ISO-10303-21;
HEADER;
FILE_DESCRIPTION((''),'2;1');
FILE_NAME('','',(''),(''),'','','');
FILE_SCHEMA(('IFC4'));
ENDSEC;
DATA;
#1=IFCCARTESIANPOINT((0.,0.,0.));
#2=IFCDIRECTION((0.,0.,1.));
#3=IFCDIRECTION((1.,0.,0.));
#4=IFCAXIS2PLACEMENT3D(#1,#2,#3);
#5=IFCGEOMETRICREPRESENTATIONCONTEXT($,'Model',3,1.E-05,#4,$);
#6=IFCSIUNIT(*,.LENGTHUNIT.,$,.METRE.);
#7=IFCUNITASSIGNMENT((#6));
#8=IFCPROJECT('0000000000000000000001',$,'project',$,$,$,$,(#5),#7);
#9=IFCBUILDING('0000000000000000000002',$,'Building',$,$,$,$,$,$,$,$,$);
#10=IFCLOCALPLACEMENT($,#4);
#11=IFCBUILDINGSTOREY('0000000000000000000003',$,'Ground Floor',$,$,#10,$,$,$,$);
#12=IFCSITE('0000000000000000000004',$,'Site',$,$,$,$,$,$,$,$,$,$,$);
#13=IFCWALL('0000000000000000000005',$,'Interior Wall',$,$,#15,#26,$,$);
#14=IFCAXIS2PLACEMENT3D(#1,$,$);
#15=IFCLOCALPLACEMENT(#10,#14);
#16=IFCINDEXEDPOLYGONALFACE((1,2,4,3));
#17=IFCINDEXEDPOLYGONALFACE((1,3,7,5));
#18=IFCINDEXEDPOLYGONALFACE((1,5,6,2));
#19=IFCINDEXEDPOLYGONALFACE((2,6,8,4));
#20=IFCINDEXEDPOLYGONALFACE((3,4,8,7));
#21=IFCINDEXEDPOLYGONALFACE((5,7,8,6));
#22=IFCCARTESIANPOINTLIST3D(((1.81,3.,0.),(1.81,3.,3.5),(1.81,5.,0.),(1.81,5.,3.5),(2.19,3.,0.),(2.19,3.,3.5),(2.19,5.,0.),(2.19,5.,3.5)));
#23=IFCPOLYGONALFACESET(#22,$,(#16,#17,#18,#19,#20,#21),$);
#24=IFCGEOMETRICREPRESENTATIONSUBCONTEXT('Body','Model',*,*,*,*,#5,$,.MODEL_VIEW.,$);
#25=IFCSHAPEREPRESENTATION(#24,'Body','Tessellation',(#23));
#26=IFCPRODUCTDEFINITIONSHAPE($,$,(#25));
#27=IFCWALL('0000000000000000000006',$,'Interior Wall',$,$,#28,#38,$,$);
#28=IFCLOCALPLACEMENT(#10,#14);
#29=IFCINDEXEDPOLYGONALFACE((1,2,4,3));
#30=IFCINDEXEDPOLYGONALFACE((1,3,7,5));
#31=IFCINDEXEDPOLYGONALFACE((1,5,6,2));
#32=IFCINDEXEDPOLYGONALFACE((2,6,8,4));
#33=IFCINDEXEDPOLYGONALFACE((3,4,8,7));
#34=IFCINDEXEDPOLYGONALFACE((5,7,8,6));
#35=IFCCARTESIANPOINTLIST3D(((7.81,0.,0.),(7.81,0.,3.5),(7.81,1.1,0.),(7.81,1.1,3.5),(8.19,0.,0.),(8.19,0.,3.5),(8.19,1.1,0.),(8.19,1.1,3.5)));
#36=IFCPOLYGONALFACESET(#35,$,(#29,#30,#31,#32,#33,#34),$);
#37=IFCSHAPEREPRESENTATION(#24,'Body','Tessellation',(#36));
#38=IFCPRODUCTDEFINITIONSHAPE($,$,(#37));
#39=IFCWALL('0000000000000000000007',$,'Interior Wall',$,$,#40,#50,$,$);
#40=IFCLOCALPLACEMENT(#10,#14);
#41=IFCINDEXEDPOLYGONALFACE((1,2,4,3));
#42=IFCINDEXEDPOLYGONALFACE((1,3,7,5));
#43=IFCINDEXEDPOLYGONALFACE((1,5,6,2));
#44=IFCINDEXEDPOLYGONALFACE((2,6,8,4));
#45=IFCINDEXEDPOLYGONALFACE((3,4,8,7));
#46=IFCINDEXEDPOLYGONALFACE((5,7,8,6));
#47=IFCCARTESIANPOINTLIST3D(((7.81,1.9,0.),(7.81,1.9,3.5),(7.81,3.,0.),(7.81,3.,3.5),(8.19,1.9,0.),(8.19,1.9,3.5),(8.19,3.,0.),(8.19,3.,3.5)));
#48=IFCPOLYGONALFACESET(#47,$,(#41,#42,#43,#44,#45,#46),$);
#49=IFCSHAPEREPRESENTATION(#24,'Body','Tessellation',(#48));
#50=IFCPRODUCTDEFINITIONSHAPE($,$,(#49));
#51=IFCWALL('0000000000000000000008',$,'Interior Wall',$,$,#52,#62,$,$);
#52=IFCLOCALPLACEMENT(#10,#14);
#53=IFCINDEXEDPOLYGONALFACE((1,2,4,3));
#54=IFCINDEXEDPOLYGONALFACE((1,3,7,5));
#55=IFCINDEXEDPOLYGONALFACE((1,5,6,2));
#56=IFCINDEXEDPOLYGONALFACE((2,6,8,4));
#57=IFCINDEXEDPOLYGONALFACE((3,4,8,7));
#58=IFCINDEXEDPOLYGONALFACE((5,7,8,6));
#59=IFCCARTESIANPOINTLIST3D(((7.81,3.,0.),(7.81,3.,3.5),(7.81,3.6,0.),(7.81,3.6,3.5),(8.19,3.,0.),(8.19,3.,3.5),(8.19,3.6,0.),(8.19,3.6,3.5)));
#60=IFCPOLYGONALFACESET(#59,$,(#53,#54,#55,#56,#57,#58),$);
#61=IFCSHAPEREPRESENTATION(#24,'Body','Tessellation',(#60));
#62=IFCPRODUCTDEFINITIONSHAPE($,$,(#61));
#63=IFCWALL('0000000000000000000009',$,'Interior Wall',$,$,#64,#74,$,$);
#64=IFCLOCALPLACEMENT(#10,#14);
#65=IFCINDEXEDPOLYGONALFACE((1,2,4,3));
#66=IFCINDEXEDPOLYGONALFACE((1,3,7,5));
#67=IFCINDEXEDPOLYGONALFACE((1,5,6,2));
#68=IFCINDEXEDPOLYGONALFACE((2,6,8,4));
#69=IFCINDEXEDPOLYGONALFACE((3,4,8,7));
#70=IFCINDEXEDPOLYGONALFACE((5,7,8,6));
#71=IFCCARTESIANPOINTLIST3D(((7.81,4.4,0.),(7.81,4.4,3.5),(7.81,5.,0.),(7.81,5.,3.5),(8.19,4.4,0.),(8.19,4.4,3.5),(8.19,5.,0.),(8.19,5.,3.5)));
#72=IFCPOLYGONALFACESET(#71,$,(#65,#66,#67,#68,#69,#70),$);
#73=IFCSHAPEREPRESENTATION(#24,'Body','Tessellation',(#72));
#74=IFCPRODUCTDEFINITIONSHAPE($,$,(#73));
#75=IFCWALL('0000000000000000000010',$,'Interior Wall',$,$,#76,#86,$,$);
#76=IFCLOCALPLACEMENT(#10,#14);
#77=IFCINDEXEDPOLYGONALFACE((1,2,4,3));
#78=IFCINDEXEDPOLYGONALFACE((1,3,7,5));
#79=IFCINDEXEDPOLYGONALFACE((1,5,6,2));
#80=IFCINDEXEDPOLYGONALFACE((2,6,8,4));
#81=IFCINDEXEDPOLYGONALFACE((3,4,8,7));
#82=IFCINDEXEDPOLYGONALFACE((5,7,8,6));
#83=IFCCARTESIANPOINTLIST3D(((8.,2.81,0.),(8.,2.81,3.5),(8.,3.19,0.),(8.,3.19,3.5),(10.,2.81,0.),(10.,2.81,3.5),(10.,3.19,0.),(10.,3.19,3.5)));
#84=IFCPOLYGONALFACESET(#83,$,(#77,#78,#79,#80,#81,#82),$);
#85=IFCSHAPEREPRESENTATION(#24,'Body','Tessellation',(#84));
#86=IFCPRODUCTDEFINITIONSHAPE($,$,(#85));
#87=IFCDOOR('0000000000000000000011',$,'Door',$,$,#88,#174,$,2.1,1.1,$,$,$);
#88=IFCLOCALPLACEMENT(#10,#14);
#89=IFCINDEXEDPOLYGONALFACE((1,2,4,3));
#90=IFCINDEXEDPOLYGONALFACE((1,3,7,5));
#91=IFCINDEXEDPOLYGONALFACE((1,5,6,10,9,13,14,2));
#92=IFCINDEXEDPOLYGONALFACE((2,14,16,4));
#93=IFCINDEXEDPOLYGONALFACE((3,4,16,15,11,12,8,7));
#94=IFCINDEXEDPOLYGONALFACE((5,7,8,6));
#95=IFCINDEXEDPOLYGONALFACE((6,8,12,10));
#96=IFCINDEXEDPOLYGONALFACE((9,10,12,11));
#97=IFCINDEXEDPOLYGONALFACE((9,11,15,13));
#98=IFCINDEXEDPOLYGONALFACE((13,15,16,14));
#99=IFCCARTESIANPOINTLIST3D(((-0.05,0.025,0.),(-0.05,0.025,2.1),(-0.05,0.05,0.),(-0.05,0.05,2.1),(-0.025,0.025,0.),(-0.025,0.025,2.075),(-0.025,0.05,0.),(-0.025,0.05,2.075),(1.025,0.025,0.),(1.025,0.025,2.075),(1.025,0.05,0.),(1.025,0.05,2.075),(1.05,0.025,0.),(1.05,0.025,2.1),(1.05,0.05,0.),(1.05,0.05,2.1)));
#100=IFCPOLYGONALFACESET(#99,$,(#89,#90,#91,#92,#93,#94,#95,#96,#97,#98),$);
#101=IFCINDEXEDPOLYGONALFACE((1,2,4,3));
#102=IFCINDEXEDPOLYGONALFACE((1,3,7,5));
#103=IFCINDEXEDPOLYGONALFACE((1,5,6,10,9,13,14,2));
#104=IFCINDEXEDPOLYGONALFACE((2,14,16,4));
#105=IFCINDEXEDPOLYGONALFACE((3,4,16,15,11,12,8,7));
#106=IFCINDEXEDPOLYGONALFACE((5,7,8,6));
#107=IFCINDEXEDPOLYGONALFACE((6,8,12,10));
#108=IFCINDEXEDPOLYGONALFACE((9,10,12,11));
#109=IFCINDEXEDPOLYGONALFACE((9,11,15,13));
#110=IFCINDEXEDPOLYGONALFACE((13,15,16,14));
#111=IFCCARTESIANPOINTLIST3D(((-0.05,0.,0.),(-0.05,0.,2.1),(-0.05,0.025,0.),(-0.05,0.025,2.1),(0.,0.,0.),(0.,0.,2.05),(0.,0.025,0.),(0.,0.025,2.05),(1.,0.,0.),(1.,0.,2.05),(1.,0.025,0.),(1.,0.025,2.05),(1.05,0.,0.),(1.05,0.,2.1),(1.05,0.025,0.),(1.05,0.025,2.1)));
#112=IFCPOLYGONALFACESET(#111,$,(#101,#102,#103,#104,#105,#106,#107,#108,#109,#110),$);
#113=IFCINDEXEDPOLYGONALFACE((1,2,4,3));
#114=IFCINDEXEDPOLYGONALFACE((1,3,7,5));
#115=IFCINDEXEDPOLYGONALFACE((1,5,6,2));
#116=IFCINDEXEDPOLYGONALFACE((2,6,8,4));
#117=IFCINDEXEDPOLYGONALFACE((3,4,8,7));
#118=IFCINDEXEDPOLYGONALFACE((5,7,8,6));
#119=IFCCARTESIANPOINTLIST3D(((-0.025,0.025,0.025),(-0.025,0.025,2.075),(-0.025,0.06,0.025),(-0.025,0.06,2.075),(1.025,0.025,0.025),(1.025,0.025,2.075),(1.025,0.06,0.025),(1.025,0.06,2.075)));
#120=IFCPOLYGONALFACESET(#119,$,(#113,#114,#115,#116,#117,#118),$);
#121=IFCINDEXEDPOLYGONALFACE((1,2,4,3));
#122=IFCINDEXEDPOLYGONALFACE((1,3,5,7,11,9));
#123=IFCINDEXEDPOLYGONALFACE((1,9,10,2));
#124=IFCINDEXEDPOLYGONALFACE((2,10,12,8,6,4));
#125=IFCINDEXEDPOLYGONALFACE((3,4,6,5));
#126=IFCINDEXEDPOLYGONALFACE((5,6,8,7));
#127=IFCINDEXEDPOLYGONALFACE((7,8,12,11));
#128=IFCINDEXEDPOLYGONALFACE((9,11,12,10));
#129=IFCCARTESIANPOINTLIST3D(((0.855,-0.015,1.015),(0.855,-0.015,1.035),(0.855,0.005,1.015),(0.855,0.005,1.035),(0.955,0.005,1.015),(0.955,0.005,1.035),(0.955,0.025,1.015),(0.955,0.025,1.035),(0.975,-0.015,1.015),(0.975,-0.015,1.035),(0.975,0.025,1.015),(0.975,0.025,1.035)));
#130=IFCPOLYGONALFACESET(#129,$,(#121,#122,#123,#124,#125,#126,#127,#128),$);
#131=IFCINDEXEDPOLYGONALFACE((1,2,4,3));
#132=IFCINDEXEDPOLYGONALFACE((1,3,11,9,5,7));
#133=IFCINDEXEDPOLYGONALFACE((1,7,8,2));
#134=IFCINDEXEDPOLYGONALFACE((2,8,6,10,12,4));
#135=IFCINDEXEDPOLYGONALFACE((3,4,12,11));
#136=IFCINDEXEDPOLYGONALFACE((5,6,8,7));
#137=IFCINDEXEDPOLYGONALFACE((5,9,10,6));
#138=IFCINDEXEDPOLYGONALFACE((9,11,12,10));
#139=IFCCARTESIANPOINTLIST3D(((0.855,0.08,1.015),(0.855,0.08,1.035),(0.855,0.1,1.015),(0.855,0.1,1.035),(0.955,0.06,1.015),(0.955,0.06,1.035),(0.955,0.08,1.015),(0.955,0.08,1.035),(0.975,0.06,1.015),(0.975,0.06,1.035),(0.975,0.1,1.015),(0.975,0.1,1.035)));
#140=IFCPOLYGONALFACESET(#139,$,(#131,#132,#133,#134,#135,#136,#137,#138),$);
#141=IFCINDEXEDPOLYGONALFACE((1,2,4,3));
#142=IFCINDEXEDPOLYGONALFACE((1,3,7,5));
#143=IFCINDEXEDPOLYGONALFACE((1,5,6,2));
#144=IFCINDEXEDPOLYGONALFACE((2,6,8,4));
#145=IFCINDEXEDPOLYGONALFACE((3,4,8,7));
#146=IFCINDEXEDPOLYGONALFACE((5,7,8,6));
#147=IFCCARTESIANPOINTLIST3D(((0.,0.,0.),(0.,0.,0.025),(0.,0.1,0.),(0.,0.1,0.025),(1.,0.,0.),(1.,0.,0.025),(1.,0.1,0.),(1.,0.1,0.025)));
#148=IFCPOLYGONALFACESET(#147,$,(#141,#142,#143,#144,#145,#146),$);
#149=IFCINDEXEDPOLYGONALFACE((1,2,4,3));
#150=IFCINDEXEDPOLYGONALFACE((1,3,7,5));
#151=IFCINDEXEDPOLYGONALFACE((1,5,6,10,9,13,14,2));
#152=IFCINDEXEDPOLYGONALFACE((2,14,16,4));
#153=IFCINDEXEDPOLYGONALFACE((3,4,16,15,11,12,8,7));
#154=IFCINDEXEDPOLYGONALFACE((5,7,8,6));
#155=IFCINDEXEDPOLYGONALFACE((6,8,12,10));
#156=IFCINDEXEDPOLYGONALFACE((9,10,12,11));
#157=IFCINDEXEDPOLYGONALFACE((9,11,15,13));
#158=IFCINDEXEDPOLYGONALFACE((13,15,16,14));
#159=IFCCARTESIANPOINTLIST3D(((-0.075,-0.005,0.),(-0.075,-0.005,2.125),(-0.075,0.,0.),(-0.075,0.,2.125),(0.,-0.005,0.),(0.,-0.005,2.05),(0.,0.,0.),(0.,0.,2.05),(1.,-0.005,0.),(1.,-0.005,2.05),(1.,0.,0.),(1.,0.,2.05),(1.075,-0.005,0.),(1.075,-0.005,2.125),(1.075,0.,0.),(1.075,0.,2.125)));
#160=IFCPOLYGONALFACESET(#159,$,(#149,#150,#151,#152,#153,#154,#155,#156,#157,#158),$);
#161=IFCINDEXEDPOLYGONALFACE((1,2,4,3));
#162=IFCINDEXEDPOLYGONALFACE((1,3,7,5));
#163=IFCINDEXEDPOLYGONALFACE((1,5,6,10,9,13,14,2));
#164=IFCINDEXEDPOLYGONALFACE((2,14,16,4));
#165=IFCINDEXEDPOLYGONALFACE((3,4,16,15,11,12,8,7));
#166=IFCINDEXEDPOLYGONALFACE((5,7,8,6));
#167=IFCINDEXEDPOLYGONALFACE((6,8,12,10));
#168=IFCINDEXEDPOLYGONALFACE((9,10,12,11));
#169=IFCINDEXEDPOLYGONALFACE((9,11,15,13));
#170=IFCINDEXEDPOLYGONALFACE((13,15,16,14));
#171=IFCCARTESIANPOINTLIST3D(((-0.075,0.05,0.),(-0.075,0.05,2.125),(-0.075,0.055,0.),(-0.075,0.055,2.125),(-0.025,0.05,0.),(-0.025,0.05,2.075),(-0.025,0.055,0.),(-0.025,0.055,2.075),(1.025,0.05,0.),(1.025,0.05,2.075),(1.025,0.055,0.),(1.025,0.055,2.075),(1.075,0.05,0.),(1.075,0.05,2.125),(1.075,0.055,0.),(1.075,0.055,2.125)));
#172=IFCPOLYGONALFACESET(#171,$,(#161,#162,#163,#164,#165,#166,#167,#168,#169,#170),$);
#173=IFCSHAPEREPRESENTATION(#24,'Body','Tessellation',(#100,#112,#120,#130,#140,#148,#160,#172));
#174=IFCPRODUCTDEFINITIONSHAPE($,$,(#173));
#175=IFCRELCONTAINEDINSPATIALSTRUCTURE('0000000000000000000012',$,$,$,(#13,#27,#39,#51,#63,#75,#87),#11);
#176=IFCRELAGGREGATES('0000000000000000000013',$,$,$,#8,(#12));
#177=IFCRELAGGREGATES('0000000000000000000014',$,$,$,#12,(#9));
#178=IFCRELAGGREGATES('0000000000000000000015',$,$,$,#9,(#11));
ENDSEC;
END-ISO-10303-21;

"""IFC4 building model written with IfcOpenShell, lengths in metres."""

from ifc_helpers import new_model, si_unit, frame, origin_with_axes, place, context, subcontext, project, spatial, line, indexed_curve, outline, extrude, element, save


model = new_model("IFC4")

# Units and contexts
model_context = context("Model", 3, precision=1e-05, world=origin_with_axes())
body_context = subcontext(model_context, "Body", "Model", "MODEL_VIEW")
ifc_project = project(units=[si_unit("LENGTHUNIT", "METRE")], contexts=[model_context])

# Site, building, storey
site = spatial("IfcSite", under=ifc_project, Name="Site")
building = spatial("IfcBuilding", under=site, Name="Building")
storey_placement = place(None, origin_with_axes())
storey = spatial("IfcBuildingStorey", under=building, at=storey_placement, Name="Ground Floor")

# Walls
wall_1_placement = place(storey_placement, frame((2.0, 5.0, 0.0), z_axis=(0.0, 0.0, 1.0), x_axis=(0.0, -1.0, 0.0)))
element("IfcWall", 1, at=wall_1_placement, inside=storey, Name="Interior Wall", context=body_context, shape_type="SweptSolid", body=[
    extrude(outline(indexed_curve([(0.0, 0.0), (0.0, 0.38), (2.0, 0.38), (2.0, 0.0), (0.0, 0.0)], self_intersect=False)), frame((0.0, -0.19, 0.0), z_axis=(0.0, 0.0, 1.0), x_axis=(1.0, 0.0, 0.0)), (0.0, 0.0, 1.0), 3.5),
])
for number, where, z_axis, x_axis, name in (
    (2, (8.0, 0.0, 0.0), (0.0, 0.0, 1.0), (0.0, 1.0, 0.0), "Interior Wall"),
    (3, (8.0, 1.9, 0.0), (0.0, 0.0, 1.0), (0.0, 1.0, 0.0), "Interior Wall"),
):
    element("IfcWall", number, at=place(storey_placement, frame(where, z_axis=z_axis, x_axis=x_axis)), inside=storey, Name=name, context=body_context, shape_type="SweptSolid", body=[
        extrude(outline(indexed_curve([(0.0, 0.0), (0.0, 0.38), (1.1, 0.38), (1.1, 0.0), (0.0, 0.0)], self_intersect=False)), frame((0.0, -0.19, 0.0), z_axis=(0.0, 0.0, 1.0), x_axis=(1.0, 0.0, 0.0)), (0.0, 0.0, 1.0), 3.5),
    ])
wall_2_placement = place(storey_placement, frame((8.0, 3.0, 0.0), z_axis=(0.0, 0.0, 1.0), x_axis=(0.0, 1.0, 0.0)))
element("IfcWall", 4, at=wall_2_placement, inside=storey, Name="Interior Wall", context=body_context, shape_type="SweptSolid", body=[
    extrude(outline(indexed_curve([(0.0, 0.0), (0.0, 0.38), (0.6, 0.38), (0.6, 0.0), (0.0, 0.0)], self_intersect=False)), frame((0.0, -0.19, 0.0), z_axis=(0.0, 0.0, 1.0), x_axis=(1.0, 0.0, 0.0)), (0.0, 0.0, 1.0), 3.5),
])
wall_3_placement = place(storey_placement, frame((8.0, 4.4, 0.0), z_axis=(0.0, 0.0, 1.0), x_axis=(0.0, 1.0, 0.0)))
element("IfcWall", 5, at=wall_3_placement, inside=storey, Name="Interior Wall", context=body_context, shape_type="SweptSolid", body=[
    extrude(outline(indexed_curve([(0.0, 0.0), (0.0, 0.38), (0.6, 0.38), (0.6, 0.0), (0.0, 0.0)], self_intersect=False)), frame((0.0, -0.19, 0.0), z_axis=(0.0, 0.0, 1.0), x_axis=(1.0, 0.0, 0.0)), (0.0, 0.0, 1.0), 3.5),
])
wall_4_placement = place(storey_placement, frame((10.0, 3.0, 0.0), z_axis=(0.0, 0.0, 1.0), x_axis=(-1.0, 0.0, 0.0)))
element("IfcWall", 6, at=wall_4_placement, inside=storey, Name="Interior Wall", context=body_context, shape_type="SweptSolid", body=[
    extrude(outline(indexed_curve([(0.0, 0.0), (0.0, 0.38), (2.0, 0.38), (2.0, 0.0), (0.0, 0.0)], self_intersect=False)), frame((0.0, -0.19, 0.0), z_axis=(0.0, 0.0, 1.0), x_axis=(1.0, 0.0, 0.0)), (0.0, 0.0, 1.0), 3.5),
])

# Door
door_1_placement = place(storey_placement, frame((-0.05, 0.0, 0.0), z_axis=(0.0, 0.0, 1.0), x_axis=(1.0, 0.0, 0.0)))
element("IfcDoor", 7, at=door_1_placement, inside=storey, Name="Door", OverallHeight=2.1, OverallWidth=1.1, context=body_context, shape_type="SweptSolid", body=[
    extrude(outline(indexed_curve([(0.0, 0.0), (0.0, 2.1), (1.1, 2.1), (1.1, 0.0), (1.075, 0.0), (1.075, 2.075), (0.025, 2.075), (0.025, 0.0)], segments=[line(1, 2, 3, 4, 5, 6, 7, 8, 1)])), frame((0.0, 0.025, 0.0), z_axis=(0.0, -1.0, 0.0), x_axis=(1.0, 0.0, 0.0)), (0.0, 0.0, -1.0), 0.025),
    extrude(outline(indexed_curve([(0.0, 0.0), (0.0, 2.1), (1.1, 2.1), (1.1, 0.0), (1.05, 0.0), (1.05, 2.05), (0.05, 2.05), (0.05, 0.0)], segments=[line(1, 2, 3, 4, 5, 6, 7, 8, 1)])), frame((0.0, 0.0, 0.0), z_axis=(0.0, -1.0, 0.0), x_axis=(1.0, 0.0, 0.0)), (0.0, 0.0, -1.0), 0.025),
    extrude(outline(indexed_curve([(0.0, 0.0), (1.05, 0.0), (1.05, 0.035), (0.0, 0.035)], segments=[line(1, 2, 3, 4, 1)])), frame((0.025, 0.025, 0.025), z_axis=(0.0, 0.0, 1.0), x_axis=(1.0, 0.0, 0.0)), (0.0, 0.0, 1.0), 2.05),
    extrude(outline(indexed_curve([(0.0, 0.0), (0.0, -0.04), (-0.12, -0.04), (-0.12, -0.02), (-0.02, -0.02), (-0.02, 0.0)], segments=[line(1, 2, 3, 4, 5, 6, 1)])), frame((1.025, 0.025, 1.015), z_axis=(0.0, 0.0, 1.0), x_axis=(1.0, 0.0, 0.0)), (0.0, 0.0, 1.0), 0.02),
    extrude(outline(indexed_curve([(0.0, 0.0), (0.0, 0.04), (-0.12, 0.04), (-0.12, 0.02), (-0.02, 0.02), (-0.02, 0.0)], segments=[line(1, 2, 3, 4, 5, 6, 1)])), frame((1.025, 0.06, 1.015), z_axis=(0.0, 0.0, 1.0), x_axis=(1.0, 0.0, 0.0)), (0.0, 0.0, 1.0), 0.02),
    extrude(outline(indexed_curve([(0.0, 0.0), (1.0, 0.0), (1.0, 0.1), (0.0, 0.1)], segments=[line(1, 2, 3, 4, 1)])), frame((0.05, 0.0, 0.0), z_axis=(0.0, 0.0, 1.0), x_axis=(1.0, 0.0, 0.0)), (0.0, 0.0, 1.0), 0.025),
    extrude(outline(indexed_curve([(0.0, 0.0), (0.0, 2.125), (1.15, 2.125), (1.15, 0.0), (1.075, 0.0), (1.075, 2.05), (0.075, 2.05), (0.075, 0.0)], segments=[line(1, 2, 3, 4, 5, 6, 7, 8, 1)])), frame((-0.025, -0.005, 0.0), z_axis=(0.0, -1.0, 0.0), x_axis=(1.0, 0.0, 0.0)), (0.0, 0.0, -1.0), 0.005),
    extrude(outline(indexed_curve([(0.0, 0.0), (0.0, 2.125), (1.15, 2.125), (1.15, 0.0), (1.1, 0.0), (1.1, 2.075), (0.05, 2.075), (0.05, 0.0)], segments=[line(1, 2, 3, 4, 5, 6, 7, 8, 1)])), frame((-0.025, 0.05, 0.0), z_axis=(0.0, -1.0, 0.0), x_axis=(1.0, 0.0, 0.0)), (0.0, 0.0, -1.0), 0.005),
])

save(model, "model.ifc")
